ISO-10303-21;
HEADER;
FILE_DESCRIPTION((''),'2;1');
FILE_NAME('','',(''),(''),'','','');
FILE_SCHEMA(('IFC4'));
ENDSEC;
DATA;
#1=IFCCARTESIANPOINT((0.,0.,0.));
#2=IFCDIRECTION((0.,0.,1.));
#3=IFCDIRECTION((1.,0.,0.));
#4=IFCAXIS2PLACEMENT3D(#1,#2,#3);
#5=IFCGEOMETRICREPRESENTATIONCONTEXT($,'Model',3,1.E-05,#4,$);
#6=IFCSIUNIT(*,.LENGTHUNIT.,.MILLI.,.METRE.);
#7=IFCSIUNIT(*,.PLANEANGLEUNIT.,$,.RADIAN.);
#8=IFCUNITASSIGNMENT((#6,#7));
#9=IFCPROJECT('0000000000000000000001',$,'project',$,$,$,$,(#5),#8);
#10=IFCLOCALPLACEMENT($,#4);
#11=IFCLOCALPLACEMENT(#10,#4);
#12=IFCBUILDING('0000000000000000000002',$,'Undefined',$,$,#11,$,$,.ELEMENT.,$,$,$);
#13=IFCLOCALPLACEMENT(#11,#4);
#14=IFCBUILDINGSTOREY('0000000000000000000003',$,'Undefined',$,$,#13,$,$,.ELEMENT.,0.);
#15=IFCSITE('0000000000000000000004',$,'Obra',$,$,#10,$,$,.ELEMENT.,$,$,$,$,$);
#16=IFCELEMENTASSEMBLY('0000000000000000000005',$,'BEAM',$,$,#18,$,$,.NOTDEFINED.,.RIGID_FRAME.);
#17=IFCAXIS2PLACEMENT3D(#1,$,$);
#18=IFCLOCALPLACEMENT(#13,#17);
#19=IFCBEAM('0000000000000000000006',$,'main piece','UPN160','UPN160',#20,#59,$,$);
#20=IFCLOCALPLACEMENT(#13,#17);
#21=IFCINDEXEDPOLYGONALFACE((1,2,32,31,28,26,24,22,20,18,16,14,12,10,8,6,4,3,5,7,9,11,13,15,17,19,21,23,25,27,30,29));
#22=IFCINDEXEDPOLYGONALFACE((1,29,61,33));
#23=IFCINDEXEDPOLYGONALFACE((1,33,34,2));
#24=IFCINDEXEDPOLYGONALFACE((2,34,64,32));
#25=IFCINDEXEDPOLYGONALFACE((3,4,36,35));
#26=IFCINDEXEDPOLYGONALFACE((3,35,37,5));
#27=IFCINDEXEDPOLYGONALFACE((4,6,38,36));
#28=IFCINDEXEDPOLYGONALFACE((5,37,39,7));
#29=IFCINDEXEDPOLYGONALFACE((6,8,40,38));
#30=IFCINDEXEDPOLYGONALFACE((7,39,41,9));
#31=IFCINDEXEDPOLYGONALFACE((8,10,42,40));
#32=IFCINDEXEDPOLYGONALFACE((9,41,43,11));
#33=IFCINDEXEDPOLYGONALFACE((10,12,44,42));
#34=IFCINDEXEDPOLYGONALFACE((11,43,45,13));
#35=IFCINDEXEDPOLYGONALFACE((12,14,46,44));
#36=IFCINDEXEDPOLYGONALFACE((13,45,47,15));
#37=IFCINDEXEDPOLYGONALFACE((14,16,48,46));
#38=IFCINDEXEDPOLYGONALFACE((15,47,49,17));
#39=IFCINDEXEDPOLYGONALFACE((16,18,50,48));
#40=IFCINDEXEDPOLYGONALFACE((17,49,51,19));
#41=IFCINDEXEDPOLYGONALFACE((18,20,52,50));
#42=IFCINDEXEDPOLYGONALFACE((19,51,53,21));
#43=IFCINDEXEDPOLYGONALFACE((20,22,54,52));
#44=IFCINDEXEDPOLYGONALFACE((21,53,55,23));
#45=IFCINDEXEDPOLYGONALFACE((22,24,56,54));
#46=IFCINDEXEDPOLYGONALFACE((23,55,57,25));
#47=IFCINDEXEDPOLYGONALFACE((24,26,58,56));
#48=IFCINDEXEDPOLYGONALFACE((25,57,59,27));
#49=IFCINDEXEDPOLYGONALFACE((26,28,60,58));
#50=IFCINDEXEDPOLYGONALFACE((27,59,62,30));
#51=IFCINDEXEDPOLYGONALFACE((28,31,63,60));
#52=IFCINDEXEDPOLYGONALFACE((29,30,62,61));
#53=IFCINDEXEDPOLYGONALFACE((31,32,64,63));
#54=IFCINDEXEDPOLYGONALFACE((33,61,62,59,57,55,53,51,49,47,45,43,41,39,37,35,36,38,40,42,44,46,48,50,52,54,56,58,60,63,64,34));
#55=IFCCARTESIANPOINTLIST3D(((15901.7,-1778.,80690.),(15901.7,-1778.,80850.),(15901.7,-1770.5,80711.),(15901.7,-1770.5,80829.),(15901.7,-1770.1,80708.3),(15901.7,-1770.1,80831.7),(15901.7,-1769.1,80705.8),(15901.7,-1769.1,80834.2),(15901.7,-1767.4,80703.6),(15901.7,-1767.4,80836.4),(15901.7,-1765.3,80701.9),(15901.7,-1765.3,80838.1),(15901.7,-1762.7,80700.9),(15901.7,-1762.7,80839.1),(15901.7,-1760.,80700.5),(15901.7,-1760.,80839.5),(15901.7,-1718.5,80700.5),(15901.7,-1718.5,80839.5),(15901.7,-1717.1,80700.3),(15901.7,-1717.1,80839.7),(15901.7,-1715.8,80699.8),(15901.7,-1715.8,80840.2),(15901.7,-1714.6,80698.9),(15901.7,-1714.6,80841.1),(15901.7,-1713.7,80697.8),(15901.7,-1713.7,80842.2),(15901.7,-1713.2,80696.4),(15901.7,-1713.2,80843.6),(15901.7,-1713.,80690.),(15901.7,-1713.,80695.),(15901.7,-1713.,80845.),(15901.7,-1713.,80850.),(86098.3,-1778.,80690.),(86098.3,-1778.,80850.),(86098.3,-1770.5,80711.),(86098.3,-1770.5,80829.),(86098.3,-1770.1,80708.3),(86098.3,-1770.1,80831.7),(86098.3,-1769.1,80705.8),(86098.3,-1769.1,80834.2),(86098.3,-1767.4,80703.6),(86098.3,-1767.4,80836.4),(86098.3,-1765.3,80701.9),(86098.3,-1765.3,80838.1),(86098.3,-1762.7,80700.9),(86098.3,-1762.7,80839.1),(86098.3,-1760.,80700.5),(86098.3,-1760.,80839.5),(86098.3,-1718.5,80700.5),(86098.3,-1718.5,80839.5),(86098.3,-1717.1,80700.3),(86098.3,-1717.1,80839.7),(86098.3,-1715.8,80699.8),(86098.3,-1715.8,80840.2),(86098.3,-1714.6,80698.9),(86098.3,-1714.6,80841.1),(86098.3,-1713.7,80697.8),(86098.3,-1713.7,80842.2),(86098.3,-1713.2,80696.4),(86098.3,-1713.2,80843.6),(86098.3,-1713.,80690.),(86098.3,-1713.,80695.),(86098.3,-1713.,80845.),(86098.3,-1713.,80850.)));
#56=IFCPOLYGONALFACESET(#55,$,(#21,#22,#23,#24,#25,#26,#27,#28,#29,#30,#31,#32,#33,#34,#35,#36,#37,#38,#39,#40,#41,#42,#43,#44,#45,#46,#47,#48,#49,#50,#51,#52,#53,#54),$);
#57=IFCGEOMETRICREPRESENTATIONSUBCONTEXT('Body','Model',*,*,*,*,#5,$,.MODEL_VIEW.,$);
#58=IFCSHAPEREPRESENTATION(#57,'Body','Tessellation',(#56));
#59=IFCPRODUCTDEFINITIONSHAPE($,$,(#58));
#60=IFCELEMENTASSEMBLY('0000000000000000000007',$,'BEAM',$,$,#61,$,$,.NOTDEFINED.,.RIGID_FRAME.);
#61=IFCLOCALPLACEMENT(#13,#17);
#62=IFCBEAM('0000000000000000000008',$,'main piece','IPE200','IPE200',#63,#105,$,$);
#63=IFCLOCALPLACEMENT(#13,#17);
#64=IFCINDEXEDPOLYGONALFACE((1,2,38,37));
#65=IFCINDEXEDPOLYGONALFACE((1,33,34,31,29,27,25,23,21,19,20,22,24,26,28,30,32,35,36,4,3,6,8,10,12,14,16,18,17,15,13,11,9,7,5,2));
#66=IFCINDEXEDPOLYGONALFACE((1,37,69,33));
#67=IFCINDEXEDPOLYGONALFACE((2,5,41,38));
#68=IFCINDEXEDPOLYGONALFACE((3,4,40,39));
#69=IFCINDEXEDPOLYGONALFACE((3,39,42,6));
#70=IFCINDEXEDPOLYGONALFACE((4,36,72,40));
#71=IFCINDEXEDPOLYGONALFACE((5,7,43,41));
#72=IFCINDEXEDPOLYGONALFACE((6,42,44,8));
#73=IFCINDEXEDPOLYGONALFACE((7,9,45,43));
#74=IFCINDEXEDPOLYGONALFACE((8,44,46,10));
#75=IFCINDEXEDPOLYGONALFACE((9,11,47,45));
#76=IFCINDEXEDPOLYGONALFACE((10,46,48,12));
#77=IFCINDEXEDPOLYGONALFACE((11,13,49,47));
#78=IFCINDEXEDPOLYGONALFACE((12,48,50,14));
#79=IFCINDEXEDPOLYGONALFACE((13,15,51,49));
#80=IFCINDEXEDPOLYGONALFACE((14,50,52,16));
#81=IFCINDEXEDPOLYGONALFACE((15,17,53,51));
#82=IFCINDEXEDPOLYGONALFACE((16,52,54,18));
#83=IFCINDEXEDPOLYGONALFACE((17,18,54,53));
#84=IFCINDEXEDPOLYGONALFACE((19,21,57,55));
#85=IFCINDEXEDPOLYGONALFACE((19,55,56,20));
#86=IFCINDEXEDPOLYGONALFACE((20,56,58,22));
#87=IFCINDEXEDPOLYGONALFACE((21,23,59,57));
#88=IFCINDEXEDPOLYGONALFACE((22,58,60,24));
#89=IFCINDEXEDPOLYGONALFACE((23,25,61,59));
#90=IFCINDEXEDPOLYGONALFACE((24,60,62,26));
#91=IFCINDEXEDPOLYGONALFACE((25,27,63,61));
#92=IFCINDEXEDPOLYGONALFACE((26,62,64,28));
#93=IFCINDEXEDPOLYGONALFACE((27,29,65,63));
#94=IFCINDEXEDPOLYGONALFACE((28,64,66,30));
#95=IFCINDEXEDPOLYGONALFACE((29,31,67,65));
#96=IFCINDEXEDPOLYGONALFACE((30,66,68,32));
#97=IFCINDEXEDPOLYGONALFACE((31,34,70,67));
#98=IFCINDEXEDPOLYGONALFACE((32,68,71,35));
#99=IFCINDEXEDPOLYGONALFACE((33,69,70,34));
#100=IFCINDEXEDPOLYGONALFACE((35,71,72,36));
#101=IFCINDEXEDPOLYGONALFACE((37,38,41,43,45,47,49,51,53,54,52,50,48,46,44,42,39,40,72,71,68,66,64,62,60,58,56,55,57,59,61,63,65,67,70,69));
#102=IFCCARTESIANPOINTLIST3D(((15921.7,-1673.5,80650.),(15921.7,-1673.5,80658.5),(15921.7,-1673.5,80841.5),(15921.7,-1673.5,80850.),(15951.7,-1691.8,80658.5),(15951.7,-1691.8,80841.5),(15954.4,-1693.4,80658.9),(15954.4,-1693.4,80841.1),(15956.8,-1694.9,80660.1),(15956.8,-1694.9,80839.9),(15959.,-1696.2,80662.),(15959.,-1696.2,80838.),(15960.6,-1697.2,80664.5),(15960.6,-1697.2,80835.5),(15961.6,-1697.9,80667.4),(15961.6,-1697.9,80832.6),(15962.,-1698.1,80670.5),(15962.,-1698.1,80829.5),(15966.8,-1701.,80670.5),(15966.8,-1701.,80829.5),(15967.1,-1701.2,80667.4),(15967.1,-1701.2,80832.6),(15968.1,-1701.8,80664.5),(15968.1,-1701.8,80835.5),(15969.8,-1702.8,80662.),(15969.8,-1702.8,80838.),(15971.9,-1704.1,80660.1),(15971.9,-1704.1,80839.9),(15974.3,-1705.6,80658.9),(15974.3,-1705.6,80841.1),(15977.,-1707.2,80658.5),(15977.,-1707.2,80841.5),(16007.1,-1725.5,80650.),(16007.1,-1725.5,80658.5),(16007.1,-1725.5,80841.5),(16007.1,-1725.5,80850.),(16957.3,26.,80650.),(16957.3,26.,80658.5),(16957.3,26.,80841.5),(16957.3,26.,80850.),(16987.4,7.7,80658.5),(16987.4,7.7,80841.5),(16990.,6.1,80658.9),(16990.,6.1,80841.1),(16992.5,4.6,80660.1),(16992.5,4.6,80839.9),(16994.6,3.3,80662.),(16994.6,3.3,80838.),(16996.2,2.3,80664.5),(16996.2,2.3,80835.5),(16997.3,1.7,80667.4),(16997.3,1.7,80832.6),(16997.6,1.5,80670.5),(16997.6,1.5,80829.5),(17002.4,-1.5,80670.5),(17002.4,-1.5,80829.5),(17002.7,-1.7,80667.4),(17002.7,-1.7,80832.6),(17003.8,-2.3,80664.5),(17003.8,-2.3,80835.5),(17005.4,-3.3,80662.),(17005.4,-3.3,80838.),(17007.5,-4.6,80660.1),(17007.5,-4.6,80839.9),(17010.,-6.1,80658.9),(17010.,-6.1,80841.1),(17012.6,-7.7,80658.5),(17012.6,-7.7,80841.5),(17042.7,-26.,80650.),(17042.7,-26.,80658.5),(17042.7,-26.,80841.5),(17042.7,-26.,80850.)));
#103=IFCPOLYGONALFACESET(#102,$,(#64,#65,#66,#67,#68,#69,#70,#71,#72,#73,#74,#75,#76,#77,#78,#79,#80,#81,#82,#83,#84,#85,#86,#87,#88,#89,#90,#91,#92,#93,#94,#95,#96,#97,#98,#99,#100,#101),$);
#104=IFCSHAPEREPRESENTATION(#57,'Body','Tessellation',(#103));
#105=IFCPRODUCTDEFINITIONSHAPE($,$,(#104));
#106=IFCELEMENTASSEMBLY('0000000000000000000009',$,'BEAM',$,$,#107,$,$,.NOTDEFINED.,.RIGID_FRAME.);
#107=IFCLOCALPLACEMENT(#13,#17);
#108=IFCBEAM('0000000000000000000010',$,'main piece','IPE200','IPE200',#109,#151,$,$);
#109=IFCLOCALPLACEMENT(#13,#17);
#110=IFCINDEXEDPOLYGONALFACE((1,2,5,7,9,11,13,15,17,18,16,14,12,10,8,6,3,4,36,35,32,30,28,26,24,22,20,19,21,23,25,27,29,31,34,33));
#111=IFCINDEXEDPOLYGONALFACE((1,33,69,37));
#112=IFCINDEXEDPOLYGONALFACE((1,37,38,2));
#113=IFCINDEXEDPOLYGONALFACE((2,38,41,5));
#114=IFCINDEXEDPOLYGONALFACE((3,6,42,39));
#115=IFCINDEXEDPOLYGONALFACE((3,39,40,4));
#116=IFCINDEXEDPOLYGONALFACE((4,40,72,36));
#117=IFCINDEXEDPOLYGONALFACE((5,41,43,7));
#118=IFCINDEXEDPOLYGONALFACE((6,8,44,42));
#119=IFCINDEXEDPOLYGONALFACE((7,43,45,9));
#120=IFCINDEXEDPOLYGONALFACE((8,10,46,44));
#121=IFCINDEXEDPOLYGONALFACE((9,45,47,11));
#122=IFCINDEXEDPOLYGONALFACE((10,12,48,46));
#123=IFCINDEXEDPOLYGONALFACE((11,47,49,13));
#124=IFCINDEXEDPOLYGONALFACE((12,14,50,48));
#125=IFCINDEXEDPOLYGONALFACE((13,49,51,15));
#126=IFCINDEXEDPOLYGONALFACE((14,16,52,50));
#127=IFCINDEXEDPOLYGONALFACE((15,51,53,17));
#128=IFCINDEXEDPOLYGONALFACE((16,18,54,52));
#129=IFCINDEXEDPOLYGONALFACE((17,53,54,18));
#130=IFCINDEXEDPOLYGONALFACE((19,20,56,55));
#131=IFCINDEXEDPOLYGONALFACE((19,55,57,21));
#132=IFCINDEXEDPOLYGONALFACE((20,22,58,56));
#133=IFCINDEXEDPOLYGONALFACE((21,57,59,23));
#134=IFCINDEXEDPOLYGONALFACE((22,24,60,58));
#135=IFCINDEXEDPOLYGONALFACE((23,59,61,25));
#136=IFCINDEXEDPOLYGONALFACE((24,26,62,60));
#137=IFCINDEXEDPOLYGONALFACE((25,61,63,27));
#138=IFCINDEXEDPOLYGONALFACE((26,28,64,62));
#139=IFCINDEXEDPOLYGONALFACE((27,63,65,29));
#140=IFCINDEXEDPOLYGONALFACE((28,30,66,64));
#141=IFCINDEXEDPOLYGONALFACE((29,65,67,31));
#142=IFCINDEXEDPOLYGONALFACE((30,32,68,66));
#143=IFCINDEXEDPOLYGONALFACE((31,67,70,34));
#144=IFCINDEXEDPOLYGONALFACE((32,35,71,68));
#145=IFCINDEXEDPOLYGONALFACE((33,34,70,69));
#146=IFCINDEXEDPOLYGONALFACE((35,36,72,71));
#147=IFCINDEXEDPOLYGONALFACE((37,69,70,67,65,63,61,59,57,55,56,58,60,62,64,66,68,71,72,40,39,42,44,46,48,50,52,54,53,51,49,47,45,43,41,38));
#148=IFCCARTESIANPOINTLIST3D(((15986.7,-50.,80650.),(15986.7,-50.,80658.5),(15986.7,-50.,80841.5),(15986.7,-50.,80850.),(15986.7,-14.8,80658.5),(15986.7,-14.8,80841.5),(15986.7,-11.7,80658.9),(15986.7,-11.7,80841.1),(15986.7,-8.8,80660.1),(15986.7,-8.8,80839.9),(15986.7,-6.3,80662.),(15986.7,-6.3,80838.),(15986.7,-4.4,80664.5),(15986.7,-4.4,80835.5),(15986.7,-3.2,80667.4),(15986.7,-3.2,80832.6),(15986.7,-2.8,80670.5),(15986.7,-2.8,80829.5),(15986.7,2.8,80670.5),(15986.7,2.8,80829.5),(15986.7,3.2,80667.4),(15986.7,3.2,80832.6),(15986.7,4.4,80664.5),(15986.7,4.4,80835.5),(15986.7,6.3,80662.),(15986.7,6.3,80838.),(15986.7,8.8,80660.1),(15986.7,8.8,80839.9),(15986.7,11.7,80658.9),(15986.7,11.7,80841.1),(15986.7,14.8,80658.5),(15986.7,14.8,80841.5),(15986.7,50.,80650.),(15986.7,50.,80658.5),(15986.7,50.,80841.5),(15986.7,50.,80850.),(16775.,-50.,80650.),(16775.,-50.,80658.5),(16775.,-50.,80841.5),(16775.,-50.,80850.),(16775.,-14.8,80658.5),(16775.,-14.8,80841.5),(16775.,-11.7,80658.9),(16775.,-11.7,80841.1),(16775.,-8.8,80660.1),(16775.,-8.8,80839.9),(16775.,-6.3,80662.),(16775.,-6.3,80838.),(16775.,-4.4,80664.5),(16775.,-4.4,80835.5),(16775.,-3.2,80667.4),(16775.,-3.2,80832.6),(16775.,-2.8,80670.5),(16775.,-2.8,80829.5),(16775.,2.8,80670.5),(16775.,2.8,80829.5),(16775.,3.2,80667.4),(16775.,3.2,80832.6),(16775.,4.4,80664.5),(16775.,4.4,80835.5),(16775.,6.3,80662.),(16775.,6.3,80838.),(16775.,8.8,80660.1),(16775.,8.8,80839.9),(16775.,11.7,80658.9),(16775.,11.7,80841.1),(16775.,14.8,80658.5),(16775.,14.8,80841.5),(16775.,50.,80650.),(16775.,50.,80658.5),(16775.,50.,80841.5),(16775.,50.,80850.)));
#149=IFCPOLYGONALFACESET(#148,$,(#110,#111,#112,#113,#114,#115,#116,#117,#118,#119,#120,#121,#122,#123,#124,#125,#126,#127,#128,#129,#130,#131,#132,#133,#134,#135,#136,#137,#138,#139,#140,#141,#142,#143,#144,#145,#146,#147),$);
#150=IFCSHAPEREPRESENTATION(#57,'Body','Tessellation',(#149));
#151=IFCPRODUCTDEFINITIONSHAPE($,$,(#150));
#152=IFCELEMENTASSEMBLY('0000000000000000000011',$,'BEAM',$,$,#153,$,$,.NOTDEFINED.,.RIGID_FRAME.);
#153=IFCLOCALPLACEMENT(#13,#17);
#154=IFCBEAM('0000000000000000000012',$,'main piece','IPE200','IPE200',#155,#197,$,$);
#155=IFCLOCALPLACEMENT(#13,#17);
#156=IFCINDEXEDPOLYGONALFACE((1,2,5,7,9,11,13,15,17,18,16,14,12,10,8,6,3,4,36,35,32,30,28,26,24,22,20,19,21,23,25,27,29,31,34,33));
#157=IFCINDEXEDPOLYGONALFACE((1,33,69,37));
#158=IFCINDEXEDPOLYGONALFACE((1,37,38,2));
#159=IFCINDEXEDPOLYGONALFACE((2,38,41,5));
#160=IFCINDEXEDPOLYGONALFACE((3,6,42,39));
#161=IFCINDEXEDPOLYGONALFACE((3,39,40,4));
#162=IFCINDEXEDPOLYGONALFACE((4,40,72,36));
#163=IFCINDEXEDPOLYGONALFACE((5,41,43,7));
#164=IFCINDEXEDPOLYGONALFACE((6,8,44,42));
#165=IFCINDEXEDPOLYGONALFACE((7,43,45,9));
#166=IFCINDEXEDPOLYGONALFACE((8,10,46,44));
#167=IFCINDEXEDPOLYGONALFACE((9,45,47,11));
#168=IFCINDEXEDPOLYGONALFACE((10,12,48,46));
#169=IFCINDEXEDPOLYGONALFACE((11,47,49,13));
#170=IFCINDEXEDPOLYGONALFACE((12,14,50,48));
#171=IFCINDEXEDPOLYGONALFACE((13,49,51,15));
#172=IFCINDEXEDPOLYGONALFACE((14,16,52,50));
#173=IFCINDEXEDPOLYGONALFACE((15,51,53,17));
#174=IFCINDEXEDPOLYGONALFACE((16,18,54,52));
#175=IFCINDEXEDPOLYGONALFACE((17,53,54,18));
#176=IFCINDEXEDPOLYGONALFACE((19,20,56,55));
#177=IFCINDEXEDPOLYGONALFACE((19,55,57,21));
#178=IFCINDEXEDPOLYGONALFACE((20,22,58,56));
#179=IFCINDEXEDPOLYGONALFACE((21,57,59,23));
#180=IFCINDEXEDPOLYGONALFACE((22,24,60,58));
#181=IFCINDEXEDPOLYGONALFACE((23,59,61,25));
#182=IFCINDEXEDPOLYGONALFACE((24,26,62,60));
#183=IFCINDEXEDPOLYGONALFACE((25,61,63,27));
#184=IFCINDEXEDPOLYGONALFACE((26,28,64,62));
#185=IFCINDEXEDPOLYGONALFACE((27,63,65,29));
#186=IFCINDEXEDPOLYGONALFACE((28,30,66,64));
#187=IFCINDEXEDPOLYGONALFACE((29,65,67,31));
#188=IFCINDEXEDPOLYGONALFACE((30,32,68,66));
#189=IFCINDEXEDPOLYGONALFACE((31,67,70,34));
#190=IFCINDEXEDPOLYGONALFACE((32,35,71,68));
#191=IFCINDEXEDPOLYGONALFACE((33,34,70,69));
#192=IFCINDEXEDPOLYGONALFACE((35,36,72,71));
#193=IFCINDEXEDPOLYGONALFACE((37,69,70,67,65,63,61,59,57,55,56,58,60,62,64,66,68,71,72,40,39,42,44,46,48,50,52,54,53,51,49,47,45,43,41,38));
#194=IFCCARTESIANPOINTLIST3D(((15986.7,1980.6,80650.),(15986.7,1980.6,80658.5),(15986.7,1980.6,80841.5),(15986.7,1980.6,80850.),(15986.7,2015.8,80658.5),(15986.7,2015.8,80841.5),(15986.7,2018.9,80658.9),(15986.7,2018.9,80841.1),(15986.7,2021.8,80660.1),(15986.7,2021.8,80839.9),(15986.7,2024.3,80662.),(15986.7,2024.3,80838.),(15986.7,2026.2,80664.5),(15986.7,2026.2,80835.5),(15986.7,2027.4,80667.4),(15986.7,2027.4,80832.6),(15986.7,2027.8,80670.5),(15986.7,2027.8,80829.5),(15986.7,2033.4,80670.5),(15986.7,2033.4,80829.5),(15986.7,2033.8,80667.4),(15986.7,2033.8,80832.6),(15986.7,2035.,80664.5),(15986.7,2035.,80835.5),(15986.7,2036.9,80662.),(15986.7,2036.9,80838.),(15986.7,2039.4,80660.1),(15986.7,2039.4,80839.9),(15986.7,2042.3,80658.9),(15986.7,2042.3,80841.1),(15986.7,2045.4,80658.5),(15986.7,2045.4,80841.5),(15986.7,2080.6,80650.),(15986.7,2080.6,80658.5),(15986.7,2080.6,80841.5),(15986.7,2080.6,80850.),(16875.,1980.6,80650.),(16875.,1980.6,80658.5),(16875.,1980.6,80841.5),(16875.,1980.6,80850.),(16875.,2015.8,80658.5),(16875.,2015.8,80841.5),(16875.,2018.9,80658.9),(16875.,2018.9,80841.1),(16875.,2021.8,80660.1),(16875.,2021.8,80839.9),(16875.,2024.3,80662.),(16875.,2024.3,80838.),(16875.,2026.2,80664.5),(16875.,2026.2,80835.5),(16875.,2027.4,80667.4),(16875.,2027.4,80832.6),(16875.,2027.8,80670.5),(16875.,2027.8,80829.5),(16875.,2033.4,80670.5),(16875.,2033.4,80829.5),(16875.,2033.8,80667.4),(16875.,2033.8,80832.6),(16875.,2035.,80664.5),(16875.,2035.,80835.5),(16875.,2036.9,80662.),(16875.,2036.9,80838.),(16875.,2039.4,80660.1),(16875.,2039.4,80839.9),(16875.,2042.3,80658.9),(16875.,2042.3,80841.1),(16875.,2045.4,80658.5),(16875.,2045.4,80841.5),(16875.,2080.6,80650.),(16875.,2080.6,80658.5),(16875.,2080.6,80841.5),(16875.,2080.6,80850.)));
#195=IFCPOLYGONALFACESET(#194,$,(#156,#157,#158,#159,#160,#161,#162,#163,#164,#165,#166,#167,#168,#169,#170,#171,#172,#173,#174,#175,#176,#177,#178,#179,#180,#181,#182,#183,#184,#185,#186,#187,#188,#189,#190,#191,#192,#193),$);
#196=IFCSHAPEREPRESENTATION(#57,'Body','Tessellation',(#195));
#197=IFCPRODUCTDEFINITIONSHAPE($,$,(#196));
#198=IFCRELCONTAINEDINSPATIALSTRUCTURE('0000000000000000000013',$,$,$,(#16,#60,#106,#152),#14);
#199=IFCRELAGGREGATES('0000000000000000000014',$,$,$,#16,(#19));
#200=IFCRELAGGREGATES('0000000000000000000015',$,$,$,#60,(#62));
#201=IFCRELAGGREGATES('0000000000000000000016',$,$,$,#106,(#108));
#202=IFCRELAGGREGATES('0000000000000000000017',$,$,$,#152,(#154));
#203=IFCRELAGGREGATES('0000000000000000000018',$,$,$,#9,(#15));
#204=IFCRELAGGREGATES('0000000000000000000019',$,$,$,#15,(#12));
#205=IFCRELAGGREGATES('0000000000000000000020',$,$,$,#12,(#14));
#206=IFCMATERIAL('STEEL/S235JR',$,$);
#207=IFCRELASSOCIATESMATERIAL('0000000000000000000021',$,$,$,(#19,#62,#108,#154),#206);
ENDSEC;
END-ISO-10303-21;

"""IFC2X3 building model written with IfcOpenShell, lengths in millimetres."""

from ifc_helpers import new_model, si_unit, frame, origin_with_axes, origin_2d_with_axis, place, context, subcontext, project, spatial, i_section, u_section, extrude, material, element, aggregate, save


model = new_model("IFC2X3")

# Units and contexts
model_context = context("Model", 3, precision=1e-05, world=origin_with_axes())
body_context = subcontext(model_context, "Body", "Model", "MODEL_VIEW")
ifc_project = project(units=[si_unit("LENGTHUNIT", "METRE", prefix="MILLI"), si_unit("PLANEANGLEUNIT", "RADIAN")], contexts=[model_context])

# Site, building, storey
site_placement = place(None, origin_with_axes())
site = spatial("IfcSite", under=ifc_project, at=site_placement, Name="Obra", CompositionType="ELEMENT")
building_placement = place(site_placement, origin_with_axes())
building = spatial("IfcBuilding", under=site, at=building_placement, Name="Undefined", CompositionType="ELEMENT")
storey_placement = place(building_placement, origin_with_axes())
storey = spatial("IfcBuildingStorey", under=building, at=storey_placement, Name="Undefined", CompositionType="ELEMENT", Elevation=0.0)

# Element assemblies, beams
assembly_1_placement = place(storey_placement, origin_with_axes())
assembly_1 = element("IfcElementAssembly", 1, at=assembly_1_placement, inside=storey, Name="BEAM", AssemblyPlace="NOTDEFINED", PredefinedType="RIGID_FRAME")
ifc_material = material(Name="STEEL/S235JR")
beam_1_placement = place(assembly_1_placement, frame((15901.7, -1745.5, 80770.0), z_axis=(0.0, 0.0, -1.0), x_axis=(1.0, 0.0, 0.0)))
beam_1 = element("IfcBeam", 2, at=beam_1_placement, material=ifc_material, Name="main piece", Description="UPN160", ObjectType="UPN160", context=body_context, shape_type="SweptSolid", body=[
    extrude(u_section(Depth=160.0, FlangeWidth=65.0, WebThickness=7.5, FlangeThickness=10.5, FilletRadius=10.5, EdgeRadius=5.5, at=origin_2d_with_axis()), frame((70196.6, 0.0, 0.0), z_axis=(-1.0, 0.0, 0.0), x_axis=(0.0, -1.0, 0.0)), (0.0, 0.0, 1.0), 70196.6),
])
aggregate(assembly_1, [beam_1])
assembly_2_placement = place(storey_placement, origin_with_axes())
assembly_2 = element("IfcElementAssembly", 3, at=assembly_2_placement, inside=storey, Name="BEAM", AssemblyPlace="NOTDEFINED", PredefinedType="RIGID_FRAME")
beam_2_placement = place(assembly_2_placement, frame((17000.0, 0.0, 80750.0), z_axis=(0.0, 0.0, 1.0), x_axis=(-0.520368, -0.853942, 0.0)))
beam_2 = element("IfcBeam", 4, at=beam_2_placement, material=ifc_material, Name="main piece", Description="IPE200", ObjectType="IPE200", context=body_context, shape_type="SweptSolid", body=[
    extrude(i_section(OverallWidth=100.0, OverallDepth=200.0, WebThickness=5.6, FlangeThickness=8.5, FilletRadius=12.0, at=origin_2d_with_axis()), frame((1990.2, 0.0, 0.0), z_axis=(-1.0, 0.0, 0.0), x_axis=(0.0, -1.0, 0.0)), (0.0, 0.0, 1.0), 1990.2),
])
aggregate(assembly_2, [beam_2])
assembly_3_placement = place(storey_placement, origin_with_axes())
assembly_3 = element("IfcElementAssembly", 5, at=assembly_3_placement, inside=storey, Name="BEAM", AssemblyPlace="NOTDEFINED", PredefinedType="RIGID_FRAME")
beam_3_placement = place(assembly_3_placement, frame((16775.0, 0.0, 80750.0), z_axis=(0.0, 0.0, 1.0), x_axis=(-1.0, 0.0, 0.0)))
beam_3 = element("IfcBeam", 6, at=beam_3_placement, material=ifc_material, Name="main piece", Description="IPE200", ObjectType="IPE200", context=body_context, shape_type="SweptSolid", body=[
    extrude(i_section(OverallWidth=100.0, OverallDepth=200.0, WebThickness=5.6, FlangeThickness=8.5, FilletRadius=12.0, at=origin_2d_with_axis()), frame((788.3, 0.0, 0.0), z_axis=(-1.0, 0.0, 0.0), x_axis=(0.0, -1.0, 0.0)), (0.0, 0.0, 1.0), 788.3),
])
aggregate(assembly_3, [beam_3])
assembly_4_placement = place(storey_placement, origin_with_axes())
assembly_4 = element("IfcElementAssembly", 7, at=assembly_4_placement, inside=storey, Name="BEAM", AssemblyPlace="NOTDEFINED", PredefinedType="RIGID_FRAME")
beam_4_placement = place(assembly_4_placement, frame((16875.0, 2030.6, 80750.0), z_axis=(0.0, 0.0, 1.0), x_axis=(-1.0, 0.0, 0.0)))
beam_4 = element("IfcBeam", 8, at=beam_4_placement, material=ifc_material, Name="main piece", Description="IPE200", ObjectType="IPE200", context=body_context, shape_type="SweptSolid", body=[
    extrude(i_section(OverallWidth=100.0, OverallDepth=200.0, WebThickness=5.6, FlangeThickness=8.5, FilletRadius=12.0, at=origin_2d_with_axis()), frame((888.3, 0.0, 0.0), z_axis=(-1.0, 0.0, 0.0), x_axis=(0.0, -1.0, 0.0)), (0.0, 0.0, 1.0), 888.3),
])
aggregate(assembly_4, [beam_4])

save(model, "model.ifc")
